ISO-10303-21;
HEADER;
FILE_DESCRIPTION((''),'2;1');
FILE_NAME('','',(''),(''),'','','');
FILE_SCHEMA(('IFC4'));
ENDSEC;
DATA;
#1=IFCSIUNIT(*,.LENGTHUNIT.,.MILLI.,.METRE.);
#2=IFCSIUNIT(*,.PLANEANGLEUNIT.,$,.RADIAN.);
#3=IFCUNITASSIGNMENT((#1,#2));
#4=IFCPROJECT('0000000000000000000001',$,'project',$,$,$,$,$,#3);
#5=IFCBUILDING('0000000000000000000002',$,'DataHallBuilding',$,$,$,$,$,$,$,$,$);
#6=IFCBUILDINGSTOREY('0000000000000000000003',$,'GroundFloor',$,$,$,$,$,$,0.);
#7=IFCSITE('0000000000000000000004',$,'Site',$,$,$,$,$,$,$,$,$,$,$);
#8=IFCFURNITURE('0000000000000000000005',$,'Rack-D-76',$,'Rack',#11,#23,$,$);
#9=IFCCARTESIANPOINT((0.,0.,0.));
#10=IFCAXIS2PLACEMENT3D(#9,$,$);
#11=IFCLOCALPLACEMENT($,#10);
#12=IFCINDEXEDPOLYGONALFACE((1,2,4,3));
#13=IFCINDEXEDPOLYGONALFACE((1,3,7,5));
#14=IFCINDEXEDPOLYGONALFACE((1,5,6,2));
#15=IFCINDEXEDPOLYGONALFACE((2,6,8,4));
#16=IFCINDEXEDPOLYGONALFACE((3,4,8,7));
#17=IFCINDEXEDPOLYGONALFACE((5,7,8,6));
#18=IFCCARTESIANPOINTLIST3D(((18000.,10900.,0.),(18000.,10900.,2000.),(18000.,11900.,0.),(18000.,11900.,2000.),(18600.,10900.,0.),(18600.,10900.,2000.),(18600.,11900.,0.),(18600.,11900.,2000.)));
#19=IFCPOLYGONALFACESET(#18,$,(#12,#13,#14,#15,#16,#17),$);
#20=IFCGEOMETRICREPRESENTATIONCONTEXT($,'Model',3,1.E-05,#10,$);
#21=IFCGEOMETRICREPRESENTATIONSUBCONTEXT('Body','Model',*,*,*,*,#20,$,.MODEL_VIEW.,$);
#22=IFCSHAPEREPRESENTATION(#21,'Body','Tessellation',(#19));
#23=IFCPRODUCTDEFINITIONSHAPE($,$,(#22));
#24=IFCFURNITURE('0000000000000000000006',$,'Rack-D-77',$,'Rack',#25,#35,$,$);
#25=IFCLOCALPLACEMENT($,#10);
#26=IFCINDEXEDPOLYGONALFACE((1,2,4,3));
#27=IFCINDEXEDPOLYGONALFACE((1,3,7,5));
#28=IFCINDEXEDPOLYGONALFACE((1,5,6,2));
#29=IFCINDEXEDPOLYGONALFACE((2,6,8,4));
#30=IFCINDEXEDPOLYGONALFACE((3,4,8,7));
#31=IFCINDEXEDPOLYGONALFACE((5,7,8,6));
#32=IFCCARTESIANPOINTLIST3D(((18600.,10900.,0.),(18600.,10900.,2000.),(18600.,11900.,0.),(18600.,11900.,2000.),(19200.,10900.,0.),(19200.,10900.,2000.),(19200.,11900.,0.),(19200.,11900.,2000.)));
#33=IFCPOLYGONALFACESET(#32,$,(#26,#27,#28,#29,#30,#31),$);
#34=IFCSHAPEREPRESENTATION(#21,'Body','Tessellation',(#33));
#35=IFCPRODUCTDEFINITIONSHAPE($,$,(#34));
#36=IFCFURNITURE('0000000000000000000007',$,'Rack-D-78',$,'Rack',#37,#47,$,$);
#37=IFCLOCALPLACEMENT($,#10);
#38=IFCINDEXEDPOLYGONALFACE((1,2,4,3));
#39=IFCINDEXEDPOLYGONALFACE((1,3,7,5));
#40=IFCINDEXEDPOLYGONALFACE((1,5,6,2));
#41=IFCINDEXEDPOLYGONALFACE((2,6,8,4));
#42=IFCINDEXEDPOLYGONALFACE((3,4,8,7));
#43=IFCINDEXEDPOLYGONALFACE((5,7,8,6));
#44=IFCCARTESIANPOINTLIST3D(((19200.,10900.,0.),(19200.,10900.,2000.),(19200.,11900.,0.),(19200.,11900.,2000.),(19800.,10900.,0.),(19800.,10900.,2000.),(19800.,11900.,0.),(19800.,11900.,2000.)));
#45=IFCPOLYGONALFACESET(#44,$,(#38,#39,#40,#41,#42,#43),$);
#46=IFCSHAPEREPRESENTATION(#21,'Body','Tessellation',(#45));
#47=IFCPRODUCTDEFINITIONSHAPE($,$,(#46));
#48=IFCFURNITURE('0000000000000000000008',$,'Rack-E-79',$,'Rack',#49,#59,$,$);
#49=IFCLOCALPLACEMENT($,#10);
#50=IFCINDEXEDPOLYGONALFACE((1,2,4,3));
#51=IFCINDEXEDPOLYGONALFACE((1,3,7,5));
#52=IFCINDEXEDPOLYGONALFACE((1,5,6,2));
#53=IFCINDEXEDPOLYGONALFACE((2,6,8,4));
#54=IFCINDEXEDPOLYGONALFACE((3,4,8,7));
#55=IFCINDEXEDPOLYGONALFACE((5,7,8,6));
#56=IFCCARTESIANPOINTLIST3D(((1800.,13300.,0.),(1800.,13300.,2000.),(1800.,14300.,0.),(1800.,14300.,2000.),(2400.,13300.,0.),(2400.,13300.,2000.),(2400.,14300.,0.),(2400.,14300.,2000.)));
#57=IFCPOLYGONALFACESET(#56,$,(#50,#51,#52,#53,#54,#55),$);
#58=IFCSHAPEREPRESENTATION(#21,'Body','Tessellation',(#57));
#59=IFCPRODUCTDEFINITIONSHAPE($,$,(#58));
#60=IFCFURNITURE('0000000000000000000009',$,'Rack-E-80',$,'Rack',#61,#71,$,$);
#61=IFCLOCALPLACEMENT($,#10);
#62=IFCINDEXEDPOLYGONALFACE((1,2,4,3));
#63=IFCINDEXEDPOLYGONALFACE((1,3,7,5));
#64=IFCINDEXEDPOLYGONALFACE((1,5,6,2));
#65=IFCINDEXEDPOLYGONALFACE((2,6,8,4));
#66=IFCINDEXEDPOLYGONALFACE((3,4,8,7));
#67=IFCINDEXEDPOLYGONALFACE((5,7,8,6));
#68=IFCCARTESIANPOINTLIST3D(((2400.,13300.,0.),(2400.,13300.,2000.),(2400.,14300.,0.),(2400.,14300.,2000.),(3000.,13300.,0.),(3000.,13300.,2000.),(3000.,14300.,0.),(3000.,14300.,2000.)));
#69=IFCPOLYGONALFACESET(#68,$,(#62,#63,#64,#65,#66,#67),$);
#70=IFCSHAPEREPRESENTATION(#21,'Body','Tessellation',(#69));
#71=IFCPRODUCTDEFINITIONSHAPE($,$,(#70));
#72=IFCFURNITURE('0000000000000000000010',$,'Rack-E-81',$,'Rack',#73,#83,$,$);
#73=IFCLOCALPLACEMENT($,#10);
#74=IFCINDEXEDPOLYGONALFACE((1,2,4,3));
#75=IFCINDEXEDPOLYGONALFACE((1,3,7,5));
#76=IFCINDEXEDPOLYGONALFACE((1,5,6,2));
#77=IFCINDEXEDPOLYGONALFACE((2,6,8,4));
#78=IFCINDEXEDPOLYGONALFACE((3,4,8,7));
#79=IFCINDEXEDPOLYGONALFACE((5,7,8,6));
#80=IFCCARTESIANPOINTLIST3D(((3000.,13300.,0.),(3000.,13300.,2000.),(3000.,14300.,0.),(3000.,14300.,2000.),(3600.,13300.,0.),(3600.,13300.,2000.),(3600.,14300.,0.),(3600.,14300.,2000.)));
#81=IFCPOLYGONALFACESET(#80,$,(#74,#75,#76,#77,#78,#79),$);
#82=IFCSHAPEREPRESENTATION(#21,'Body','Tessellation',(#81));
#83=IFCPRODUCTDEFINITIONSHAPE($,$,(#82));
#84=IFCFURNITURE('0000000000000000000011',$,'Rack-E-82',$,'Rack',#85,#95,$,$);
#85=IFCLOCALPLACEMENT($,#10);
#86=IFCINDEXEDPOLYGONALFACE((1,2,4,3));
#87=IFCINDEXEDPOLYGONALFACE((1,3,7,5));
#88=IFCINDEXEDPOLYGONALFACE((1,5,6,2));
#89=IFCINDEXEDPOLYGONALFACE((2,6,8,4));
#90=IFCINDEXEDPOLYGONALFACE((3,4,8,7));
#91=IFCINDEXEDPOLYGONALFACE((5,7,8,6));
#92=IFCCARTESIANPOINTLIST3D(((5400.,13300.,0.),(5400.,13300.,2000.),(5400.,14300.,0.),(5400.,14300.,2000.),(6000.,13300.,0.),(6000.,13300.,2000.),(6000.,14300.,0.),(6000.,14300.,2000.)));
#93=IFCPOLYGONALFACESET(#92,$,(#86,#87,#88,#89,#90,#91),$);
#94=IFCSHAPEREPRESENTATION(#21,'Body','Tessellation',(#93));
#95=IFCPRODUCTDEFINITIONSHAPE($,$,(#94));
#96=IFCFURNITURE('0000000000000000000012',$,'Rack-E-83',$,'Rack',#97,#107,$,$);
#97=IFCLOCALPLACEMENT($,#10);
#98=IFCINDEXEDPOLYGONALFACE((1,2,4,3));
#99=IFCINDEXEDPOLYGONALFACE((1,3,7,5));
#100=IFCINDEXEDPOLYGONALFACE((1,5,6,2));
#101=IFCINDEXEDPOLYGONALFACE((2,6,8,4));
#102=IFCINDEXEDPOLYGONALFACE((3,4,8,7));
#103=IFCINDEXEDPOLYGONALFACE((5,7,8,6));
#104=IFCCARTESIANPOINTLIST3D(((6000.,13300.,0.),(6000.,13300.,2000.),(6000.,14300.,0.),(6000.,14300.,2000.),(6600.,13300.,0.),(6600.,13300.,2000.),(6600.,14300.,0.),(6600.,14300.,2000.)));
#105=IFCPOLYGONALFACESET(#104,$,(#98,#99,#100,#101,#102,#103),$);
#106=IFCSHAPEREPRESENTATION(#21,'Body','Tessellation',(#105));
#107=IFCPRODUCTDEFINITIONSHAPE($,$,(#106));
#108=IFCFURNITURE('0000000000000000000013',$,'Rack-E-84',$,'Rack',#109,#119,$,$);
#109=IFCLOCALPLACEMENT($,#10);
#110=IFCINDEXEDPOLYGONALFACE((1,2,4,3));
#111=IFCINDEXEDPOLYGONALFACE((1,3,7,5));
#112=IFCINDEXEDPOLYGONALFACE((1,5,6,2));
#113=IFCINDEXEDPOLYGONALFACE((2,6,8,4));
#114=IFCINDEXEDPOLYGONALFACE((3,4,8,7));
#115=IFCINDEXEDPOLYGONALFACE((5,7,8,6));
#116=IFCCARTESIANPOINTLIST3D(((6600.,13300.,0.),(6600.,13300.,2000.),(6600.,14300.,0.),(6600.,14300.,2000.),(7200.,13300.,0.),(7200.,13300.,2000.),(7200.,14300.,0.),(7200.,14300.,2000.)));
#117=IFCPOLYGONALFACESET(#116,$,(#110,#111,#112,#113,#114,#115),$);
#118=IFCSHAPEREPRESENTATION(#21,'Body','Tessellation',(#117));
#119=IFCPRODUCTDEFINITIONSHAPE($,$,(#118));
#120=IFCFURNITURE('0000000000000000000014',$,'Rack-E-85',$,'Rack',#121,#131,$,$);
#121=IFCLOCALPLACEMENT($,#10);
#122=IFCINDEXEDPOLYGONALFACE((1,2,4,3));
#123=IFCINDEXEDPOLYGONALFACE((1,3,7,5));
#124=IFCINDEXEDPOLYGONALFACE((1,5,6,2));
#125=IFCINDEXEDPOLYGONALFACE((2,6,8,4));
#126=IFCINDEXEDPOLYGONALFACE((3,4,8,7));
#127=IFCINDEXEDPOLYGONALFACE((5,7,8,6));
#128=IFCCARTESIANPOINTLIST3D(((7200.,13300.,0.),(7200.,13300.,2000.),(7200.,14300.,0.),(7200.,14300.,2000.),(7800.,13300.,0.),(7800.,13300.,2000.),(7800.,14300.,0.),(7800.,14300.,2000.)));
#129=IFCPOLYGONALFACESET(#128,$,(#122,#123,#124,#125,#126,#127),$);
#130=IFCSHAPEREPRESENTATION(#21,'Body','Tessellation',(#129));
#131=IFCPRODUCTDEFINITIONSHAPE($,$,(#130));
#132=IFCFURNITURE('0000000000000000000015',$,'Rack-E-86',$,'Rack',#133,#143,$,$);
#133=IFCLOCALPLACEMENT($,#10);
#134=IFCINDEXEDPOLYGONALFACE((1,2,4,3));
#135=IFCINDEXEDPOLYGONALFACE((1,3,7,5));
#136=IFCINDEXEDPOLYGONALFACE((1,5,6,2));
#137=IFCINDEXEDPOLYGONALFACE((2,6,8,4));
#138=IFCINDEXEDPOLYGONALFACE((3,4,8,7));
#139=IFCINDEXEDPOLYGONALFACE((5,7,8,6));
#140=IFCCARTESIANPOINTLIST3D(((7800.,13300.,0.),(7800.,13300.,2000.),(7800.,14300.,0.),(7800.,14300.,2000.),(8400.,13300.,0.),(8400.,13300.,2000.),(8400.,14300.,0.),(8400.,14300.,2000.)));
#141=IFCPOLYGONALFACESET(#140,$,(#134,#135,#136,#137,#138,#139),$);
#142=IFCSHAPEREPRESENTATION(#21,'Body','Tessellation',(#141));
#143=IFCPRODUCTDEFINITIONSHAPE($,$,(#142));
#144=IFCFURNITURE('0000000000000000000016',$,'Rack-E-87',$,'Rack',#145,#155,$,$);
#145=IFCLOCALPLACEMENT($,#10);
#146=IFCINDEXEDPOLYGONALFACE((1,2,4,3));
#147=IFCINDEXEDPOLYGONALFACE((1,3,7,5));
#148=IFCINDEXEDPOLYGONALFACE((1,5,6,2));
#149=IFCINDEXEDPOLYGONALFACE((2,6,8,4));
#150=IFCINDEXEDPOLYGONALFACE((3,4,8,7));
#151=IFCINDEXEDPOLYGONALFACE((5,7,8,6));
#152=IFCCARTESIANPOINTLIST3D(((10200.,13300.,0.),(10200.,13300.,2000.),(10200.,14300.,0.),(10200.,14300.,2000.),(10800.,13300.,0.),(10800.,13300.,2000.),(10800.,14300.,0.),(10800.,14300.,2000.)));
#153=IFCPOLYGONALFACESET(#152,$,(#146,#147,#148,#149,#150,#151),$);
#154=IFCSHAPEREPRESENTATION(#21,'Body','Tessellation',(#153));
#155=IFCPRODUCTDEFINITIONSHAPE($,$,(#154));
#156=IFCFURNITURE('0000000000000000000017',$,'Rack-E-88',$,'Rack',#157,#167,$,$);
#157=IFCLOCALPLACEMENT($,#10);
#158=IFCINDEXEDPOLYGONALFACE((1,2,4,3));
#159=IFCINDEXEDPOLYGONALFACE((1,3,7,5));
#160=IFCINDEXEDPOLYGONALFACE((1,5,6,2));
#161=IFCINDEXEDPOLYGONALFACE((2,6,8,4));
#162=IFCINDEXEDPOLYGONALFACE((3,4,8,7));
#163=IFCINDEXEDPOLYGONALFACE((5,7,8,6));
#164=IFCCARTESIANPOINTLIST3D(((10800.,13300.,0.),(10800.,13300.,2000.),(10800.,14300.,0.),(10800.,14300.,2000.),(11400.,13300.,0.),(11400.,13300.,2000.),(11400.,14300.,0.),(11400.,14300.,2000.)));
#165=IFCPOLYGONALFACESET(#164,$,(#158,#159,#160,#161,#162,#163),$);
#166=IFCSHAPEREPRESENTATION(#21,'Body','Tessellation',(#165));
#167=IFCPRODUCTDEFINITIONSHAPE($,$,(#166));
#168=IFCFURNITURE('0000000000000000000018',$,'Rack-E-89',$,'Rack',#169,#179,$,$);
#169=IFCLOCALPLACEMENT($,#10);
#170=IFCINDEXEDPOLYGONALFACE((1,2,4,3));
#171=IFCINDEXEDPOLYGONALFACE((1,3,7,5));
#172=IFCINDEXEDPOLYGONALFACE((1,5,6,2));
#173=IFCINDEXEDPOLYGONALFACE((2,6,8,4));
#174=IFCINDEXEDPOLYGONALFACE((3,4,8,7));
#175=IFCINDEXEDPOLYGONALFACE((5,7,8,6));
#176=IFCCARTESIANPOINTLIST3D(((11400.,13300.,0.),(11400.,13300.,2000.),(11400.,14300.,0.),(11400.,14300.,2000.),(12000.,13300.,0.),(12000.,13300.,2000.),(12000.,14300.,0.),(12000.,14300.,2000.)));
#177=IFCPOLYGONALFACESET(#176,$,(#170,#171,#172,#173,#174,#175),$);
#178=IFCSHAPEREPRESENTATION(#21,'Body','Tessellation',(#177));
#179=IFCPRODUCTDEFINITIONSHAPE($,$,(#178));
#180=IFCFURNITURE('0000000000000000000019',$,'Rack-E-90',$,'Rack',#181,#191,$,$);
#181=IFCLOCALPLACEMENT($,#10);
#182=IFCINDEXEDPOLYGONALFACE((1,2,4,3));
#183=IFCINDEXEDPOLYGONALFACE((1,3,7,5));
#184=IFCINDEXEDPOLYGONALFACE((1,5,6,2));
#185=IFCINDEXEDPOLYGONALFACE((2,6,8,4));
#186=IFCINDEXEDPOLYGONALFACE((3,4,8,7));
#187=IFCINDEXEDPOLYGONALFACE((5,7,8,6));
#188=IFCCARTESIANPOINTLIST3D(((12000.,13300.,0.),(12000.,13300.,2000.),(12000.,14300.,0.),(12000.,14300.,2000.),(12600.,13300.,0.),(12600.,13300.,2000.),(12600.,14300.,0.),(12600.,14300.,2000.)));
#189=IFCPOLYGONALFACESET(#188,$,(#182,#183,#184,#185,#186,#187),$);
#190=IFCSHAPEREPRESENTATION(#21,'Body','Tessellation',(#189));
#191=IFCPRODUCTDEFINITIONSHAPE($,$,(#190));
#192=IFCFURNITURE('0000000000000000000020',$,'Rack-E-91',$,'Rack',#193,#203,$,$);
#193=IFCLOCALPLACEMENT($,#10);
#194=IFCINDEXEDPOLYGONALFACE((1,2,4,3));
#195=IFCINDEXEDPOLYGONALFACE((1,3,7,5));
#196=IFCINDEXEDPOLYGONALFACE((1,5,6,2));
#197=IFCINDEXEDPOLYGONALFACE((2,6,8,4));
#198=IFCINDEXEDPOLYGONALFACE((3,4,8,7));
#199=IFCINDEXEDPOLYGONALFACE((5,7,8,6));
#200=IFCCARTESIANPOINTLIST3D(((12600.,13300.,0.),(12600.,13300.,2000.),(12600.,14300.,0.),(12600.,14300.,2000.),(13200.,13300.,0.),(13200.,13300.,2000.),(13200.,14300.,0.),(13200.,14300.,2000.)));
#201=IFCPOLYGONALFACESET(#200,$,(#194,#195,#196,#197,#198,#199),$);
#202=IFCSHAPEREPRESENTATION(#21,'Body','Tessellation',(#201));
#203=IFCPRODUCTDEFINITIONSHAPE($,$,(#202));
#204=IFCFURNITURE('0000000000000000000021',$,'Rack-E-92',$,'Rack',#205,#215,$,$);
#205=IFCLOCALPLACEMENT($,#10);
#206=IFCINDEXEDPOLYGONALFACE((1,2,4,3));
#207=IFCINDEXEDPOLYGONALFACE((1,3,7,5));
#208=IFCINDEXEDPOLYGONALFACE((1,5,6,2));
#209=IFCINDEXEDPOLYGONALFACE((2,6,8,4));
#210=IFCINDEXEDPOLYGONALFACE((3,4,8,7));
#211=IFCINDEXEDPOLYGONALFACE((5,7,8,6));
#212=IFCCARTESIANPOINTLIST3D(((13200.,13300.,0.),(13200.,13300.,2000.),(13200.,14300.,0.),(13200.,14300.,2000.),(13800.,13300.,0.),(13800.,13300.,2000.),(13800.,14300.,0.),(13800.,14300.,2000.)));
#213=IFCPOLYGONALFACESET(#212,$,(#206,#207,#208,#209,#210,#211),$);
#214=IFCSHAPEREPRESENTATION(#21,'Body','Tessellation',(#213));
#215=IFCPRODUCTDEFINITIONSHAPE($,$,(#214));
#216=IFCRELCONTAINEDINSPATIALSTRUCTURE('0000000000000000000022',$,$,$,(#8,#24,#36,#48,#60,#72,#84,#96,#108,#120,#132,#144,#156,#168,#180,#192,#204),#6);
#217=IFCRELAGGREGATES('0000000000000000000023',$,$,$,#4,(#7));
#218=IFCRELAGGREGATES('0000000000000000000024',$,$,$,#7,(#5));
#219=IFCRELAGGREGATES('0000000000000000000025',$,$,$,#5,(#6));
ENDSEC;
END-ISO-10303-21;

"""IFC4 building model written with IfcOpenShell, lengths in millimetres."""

from ifc_helpers import new_model, si_unit, frame, origin, place, context, subcontext, project, spatial, rectangle, extrude, element, save


model = new_model("IFC4")

# Units and contexts
model_context = context("Model", 3, precision=1e-05, world=origin())
body_context = subcontext(model_context, "Body", "Model", "MODEL_VIEW")
ifc_project = project(units=[si_unit("LENGTHUNIT", "METRE", prefix="MILLI"), si_unit("PLANEANGLEUNIT", "RADIAN")])

# Site, building, storey
site = spatial("IfcSite", under=ifc_project, Name="Site")
building = spatial("IfcBuilding", under=site, Name="DataHallBuilding")
storey = spatial("IfcBuildingStorey", under=building, Name="GroundFloor", Elevation=0.0)

# Furniture
furniture_1_placement = place(None, origin())
element("IfcFurniture", 1, at=furniture_1_placement, inside=storey, Name="Rack-D-76", ObjectType="Rack", context=body_context, shape_type="SweptSolid", body=[
    extrude(rectangle(XDim=600.0, YDim=1000.0), frame((18300.0, 11400.0, 0.0), z_axis=(0.0, 0.0, 1.0), x_axis=(1.0, 0.0, 0.0)), (0.0, 0.0, 1.0), 2000.0),
])
furniture_2_placement = place(None, origin())
element("IfcFurniture", 2, at=furniture_2_placement, inside=storey, Name="Rack-D-77", ObjectType="Rack", context=body_context, shape_type="SweptSolid", body=[
    extrude(rectangle(XDim=600.0, YDim=1000.0), frame((18900.0, 11400.0, 0.0), z_axis=(0.0, 0.0, 1.0), x_axis=(1.0, 0.0, 0.0)), (0.0, 0.0, 1.0), 2000.0),
])
furniture_3_placement = place(None, origin())
element("IfcFurniture", 3, at=furniture_3_placement, inside=storey, Name="Rack-D-78", ObjectType="Rack", context=body_context, shape_type="SweptSolid", body=[
    extrude(rectangle(XDim=600.0, YDim=1000.0), frame((19500.0, 11400.0, 0.0), z_axis=(0.0, 0.0, 1.0), x_axis=(1.0, 0.0, 0.0)), (0.0, 0.0, 1.0), 2000.0),
])
furniture_4_placement = place(None, origin())
element("IfcFurniture", 4, at=furniture_4_placement, inside=storey, Name="Rack-E-79", ObjectType="Rack", context=body_context, shape_type="SweptSolid", body=[
    extrude(rectangle(XDim=600.0, YDim=1000.0), frame((2100.0, 13800.0, 0.0), z_axis=(0.0, 0.0, 1.0), x_axis=(1.0, 0.0, 0.0)), (0.0, 0.0, 1.0), 2000.0),
])
furniture_5_placement = place(None, origin())
element("IfcFurniture", 5, at=furniture_5_placement, inside=storey, Name="Rack-E-80", ObjectType="Rack", context=body_context, shape_type="SweptSolid", body=[
    extrude(rectangle(XDim=600.0, YDim=1000.0), frame((2700.0, 13800.0, 0.0), z_axis=(0.0, 0.0, 1.0), x_axis=(1.0, 0.0, 0.0)), (0.0, 0.0, 1.0), 2000.0),
])
furniture_6_placement = place(None, origin())
element("IfcFurniture", 6, at=furniture_6_placement, inside=storey, Name="Rack-E-81", ObjectType="Rack", context=body_context, shape_type="SweptSolid", body=[
    extrude(rectangle(XDim=600.0, YDim=1000.0), frame((3300.0, 13800.0, 0.0), z_axis=(0.0, 0.0, 1.0), x_axis=(1.0, 0.0, 0.0)), (0.0, 0.0, 1.0), 2000.0),
])
furniture_7_placement = place(None, origin())
element("IfcFurniture", 7, at=furniture_7_placement, inside=storey, Name="Rack-E-82", ObjectType="Rack", context=body_context, shape_type="SweptSolid", body=[
    extrude(rectangle(XDim=600.0, YDim=1000.0), frame((5700.0, 13800.0, 0.0), z_axis=(0.0, 0.0, 1.0), x_axis=(1.0, 0.0, 0.0)), (0.0, 0.0, 1.0), 2000.0),
])
furniture_8_placement = place(None, origin())
element("IfcFurniture", 8, at=furniture_8_placement, inside=storey, Name="Rack-E-83", ObjectType="Rack", context=body_context, shape_type="SweptSolid", body=[
    extrude(rectangle(XDim=600.0, YDim=1000.0), frame((6300.0, 13800.0, 0.0), z_axis=(0.0, 0.0, 1.0), x_axis=(1.0, 0.0, 0.0)), (0.0, 0.0, 1.0), 2000.0),
])
furniture_9_placement = place(None, origin())
element("IfcFurniture", 9, at=furniture_9_placement, inside=storey, Name="Rack-E-84", ObjectType="Rack", context=body_context, shape_type="SweptSolid", body=[
    extrude(rectangle(XDim=600.0, YDim=1000.0), frame((6900.0, 13800.0, 0.0), z_axis=(0.0, 0.0, 1.0), x_axis=(1.0, 0.0, 0.0)), (0.0, 0.0, 1.0), 2000.0),
])
furniture_10_placement = place(None, origin())
element("IfcFurniture", 10, at=furniture_10_placement, inside=storey, Name="Rack-E-85", ObjectType="Rack", context=body_context, shape_type="SweptSolid", body=[
    extrude(rectangle(XDim=600.0, YDim=1000.0), frame((7500.0, 13800.0, 0.0), z_axis=(0.0, 0.0, 1.0), x_axis=(1.0, 0.0, 0.0)), (0.0, 0.0, 1.0), 2000.0),
])
furniture_11_placement = place(None, origin())
element("IfcFurniture", 11, at=furniture_11_placement, inside=storey, Name="Rack-E-86", ObjectType="Rack", context=body_context, shape_type="SweptSolid", body=[
    extrude(rectangle(XDim=600.0, YDim=1000.0), frame((8100.0, 13800.0, 0.0), z_axis=(0.0, 0.0, 1.0), x_axis=(1.0, 0.0, 0.0)), (0.0, 0.0, 1.0), 2000.0),
])
furniture_12_placement = place(None, origin())
element("IfcFurniture", 12, at=furniture_12_placement, inside=storey, Name="Rack-E-87", ObjectType="Rack", context=body_context, shape_type="SweptSolid", body=[
    extrude(rectangle(XDim=600.0, YDim=1000.0), frame((10500.0, 13800.0, 0.0), z_axis=(0.0, 0.0, 1.0), x_axis=(1.0, 0.0, 0.0)), (0.0, 0.0, 1.0), 2000.0),
])
furniture_13_placement = place(None, origin())
element("IfcFurniture", 13, at=furniture_13_placement, inside=storey, Name="Rack-E-88", ObjectType="Rack", context=body_context, shape_type="SweptSolid", body=[
    extrude(rectangle(XDim=600.0, YDim=1000.0), frame((11100.0, 13800.0, 0.0), z_axis=(0.0, 0.0, 1.0), x_axis=(1.0, 0.0, 0.0)), (0.0, 0.0, 1.0), 2000.0),
])
furniture_14_placement = place(None, origin())
element("IfcFurniture", 14, at=furniture_14_placement, inside=storey, Name="Rack-E-89", ObjectType="Rack", context=body_context, shape_type="SweptSolid", body=[
    extrude(rectangle(XDim=600.0, YDim=1000.0), frame((11700.0, 13800.0, 0.0), z_axis=(0.0, 0.0, 1.0), x_axis=(1.0, 0.0, 0.0)), (0.0, 0.0, 1.0), 2000.0),
])
furniture_15_placement = place(None, origin())
element("IfcFurniture", 15, at=furniture_15_placement, inside=storey, Name="Rack-E-90", ObjectType="Rack", context=body_context, shape_type="SweptSolid", body=[
    extrude(rectangle(XDim=600.0, YDim=1000.0), frame((12300.0, 13800.0, 0.0), z_axis=(0.0, 0.0, 1.0), x_axis=(1.0, 0.0, 0.0)), (0.0, 0.0, 1.0), 2000.0),
])
furniture_16_placement = place(None, origin())
element("IfcFurniture", 16, at=furniture_16_placement, inside=storey, Name="Rack-E-91", ObjectType="Rack", context=body_context, shape_type="SweptSolid", body=[
    extrude(rectangle(XDim=600.0, YDim=1000.0), frame((12900.0, 13800.0, 0.0), z_axis=(0.0, 0.0, 1.0), x_axis=(1.0, 0.0, 0.0)), (0.0, 0.0, 1.0), 2000.0),
])
furniture_17_placement = place(None, origin())
element("IfcFurniture", 17, at=furniture_17_placement, inside=storey, Name="Rack-E-92", ObjectType="Rack", context=body_context, shape_type="SweptSolid", body=[
    extrude(rectangle(XDim=600.0, YDim=1000.0), frame((13500.0, 13800.0, 0.0), z_axis=(0.0, 0.0, 1.0), x_axis=(1.0, 0.0, 0.0)), (0.0, 0.0, 1.0), 2000.0),
])

save(model, "model.ifc")
